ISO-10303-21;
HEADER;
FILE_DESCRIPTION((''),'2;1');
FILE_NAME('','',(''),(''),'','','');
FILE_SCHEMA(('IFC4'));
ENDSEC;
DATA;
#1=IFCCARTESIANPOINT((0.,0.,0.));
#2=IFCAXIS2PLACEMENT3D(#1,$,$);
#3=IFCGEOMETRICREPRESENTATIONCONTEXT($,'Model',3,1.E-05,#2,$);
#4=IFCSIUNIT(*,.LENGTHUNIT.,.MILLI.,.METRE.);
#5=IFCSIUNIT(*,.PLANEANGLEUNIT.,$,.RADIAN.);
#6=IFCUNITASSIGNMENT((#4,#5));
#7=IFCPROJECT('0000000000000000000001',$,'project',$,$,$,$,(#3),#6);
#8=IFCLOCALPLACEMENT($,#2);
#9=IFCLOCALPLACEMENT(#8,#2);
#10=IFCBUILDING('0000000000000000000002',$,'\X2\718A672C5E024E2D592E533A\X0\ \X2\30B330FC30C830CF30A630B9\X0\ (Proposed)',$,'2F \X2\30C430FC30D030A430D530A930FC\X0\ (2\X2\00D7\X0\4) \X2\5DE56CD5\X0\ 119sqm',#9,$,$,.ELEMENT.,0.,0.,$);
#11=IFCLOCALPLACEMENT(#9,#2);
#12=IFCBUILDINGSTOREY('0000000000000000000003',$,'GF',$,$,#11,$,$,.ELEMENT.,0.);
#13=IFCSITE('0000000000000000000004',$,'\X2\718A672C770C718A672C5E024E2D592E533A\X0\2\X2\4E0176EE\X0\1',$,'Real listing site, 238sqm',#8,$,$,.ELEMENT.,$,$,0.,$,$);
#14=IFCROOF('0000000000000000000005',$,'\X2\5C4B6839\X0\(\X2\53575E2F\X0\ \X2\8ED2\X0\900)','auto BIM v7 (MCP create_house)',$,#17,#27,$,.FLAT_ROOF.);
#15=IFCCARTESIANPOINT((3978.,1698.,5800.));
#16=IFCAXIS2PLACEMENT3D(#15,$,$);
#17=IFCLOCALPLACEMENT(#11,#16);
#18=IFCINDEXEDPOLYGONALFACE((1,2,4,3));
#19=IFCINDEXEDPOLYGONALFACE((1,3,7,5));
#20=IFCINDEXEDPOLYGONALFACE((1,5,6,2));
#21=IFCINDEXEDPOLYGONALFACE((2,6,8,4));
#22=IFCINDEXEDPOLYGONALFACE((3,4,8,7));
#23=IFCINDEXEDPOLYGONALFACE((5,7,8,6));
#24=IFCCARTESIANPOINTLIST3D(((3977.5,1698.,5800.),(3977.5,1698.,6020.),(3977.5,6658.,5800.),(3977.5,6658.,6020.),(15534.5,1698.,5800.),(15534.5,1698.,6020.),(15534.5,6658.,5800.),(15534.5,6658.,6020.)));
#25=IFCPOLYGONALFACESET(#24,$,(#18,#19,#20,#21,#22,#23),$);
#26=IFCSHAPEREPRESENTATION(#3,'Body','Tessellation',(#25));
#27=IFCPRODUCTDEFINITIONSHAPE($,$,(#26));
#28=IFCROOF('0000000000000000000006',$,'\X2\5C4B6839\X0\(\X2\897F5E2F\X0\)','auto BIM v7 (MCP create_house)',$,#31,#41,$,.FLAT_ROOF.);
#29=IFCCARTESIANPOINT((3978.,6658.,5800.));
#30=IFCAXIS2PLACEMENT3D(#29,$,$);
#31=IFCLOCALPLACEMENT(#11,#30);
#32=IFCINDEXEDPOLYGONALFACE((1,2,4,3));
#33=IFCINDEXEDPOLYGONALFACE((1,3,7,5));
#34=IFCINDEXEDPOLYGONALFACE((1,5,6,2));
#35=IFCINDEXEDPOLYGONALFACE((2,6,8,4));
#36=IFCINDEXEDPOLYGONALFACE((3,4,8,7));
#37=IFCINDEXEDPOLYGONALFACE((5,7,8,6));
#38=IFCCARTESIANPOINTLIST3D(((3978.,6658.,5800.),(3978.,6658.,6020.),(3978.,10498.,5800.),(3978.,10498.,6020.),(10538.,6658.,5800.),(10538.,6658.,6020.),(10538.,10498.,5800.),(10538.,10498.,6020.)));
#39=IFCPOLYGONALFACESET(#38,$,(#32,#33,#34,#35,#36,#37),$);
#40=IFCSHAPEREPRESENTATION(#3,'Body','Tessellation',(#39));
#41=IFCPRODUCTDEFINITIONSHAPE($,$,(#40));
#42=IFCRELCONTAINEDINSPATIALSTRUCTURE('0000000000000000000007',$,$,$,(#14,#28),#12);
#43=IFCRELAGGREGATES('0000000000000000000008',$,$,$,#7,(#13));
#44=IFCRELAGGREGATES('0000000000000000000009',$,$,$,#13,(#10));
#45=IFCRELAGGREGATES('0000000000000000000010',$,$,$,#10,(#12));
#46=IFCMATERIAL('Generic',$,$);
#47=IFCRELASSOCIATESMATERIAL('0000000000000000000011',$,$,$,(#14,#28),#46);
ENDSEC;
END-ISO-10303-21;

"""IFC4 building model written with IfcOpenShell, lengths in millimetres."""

from ifc_helpers import new_model, si_unit, frame, frame_2d, origin, place, context, project, spatial, rectangle, extrude, material, element, save


model = new_model("IFC4")

# Units and contexts
model_context = context("Model", 3, precision=1e-05, world=origin())
ifc_project = project(units=[si_unit("LENGTHUNIT", "METRE", prefix="MILLI"), si_unit("PLANEANGLEUNIT", "RADIAN")], contexts=[model_context])

# Site, building, storey
site_placement = place(None, origin())
site = spatial("IfcSite", under=ifc_project, at=site_placement, Name="熊本県熊本市中央区2丁目1", ObjectType="Real listing site, 238sqm", CompositionType="ELEMENT", RefElevation=0.0)
building_placement = place(site_placement, origin())
building = spatial("IfcBuilding", under=site, at=building_placement, Name="熊本市中央区 コートハウス (Proposed)", ObjectType="2F ツーバイフォー (2×4) 工法 119sqm", CompositionType="ELEMENT", ElevationOfRefHeight=0.0, ElevationOfTerrain=0.0)
storey_placement = place(building_placement, origin())
storey = spatial("IfcBuildingStorey", under=building, at=storey_placement, Name="GF", CompositionType="ELEMENT", Elevation=0.0)

# Shared definitions
ifc_material = material(Name="Generic")

# Roofs
roof_1_placement = place(storey_placement, frame((3978.0, 1698.0, 5800.0)))
element("IfcRoof", 1, at=roof_1_placement, inside=storey, material=ifc_material, Name="屋根(南帯 軒900)", Description="auto BIM v7 (MCP create_house)", PredefinedType="FLAT_ROOF", context=model_context, shape_type="SweptSolid", body=[
    extrude(rectangle(XDim=11557.0, YDim=4960.0, at=frame_2d((5778.0, 2480.0))), frame((3978.0, 1698.0, 5800.0)), (0.0, 0.0, 1.0), 220.0),
])
roof_2_placement = place(storey_placement, frame((3978.0, 6658.0, 5800.0)))
element("IfcRoof", 2, at=roof_2_placement, inside=storey, material=ifc_material, Name="屋根(西帯)", Description="auto BIM v7 (MCP create_house)", PredefinedType="FLAT_ROOF", context=model_context, shape_type="SweptSolid", body=[
    extrude(rectangle(XDim=6560.0, YDim=3840.0, at=frame_2d((3280.0, 1920.0))), frame((3978.0, 6658.0, 5800.0)), (0.0, 0.0, 1.0), 220.0),
])

save(model, "model.ifc")
